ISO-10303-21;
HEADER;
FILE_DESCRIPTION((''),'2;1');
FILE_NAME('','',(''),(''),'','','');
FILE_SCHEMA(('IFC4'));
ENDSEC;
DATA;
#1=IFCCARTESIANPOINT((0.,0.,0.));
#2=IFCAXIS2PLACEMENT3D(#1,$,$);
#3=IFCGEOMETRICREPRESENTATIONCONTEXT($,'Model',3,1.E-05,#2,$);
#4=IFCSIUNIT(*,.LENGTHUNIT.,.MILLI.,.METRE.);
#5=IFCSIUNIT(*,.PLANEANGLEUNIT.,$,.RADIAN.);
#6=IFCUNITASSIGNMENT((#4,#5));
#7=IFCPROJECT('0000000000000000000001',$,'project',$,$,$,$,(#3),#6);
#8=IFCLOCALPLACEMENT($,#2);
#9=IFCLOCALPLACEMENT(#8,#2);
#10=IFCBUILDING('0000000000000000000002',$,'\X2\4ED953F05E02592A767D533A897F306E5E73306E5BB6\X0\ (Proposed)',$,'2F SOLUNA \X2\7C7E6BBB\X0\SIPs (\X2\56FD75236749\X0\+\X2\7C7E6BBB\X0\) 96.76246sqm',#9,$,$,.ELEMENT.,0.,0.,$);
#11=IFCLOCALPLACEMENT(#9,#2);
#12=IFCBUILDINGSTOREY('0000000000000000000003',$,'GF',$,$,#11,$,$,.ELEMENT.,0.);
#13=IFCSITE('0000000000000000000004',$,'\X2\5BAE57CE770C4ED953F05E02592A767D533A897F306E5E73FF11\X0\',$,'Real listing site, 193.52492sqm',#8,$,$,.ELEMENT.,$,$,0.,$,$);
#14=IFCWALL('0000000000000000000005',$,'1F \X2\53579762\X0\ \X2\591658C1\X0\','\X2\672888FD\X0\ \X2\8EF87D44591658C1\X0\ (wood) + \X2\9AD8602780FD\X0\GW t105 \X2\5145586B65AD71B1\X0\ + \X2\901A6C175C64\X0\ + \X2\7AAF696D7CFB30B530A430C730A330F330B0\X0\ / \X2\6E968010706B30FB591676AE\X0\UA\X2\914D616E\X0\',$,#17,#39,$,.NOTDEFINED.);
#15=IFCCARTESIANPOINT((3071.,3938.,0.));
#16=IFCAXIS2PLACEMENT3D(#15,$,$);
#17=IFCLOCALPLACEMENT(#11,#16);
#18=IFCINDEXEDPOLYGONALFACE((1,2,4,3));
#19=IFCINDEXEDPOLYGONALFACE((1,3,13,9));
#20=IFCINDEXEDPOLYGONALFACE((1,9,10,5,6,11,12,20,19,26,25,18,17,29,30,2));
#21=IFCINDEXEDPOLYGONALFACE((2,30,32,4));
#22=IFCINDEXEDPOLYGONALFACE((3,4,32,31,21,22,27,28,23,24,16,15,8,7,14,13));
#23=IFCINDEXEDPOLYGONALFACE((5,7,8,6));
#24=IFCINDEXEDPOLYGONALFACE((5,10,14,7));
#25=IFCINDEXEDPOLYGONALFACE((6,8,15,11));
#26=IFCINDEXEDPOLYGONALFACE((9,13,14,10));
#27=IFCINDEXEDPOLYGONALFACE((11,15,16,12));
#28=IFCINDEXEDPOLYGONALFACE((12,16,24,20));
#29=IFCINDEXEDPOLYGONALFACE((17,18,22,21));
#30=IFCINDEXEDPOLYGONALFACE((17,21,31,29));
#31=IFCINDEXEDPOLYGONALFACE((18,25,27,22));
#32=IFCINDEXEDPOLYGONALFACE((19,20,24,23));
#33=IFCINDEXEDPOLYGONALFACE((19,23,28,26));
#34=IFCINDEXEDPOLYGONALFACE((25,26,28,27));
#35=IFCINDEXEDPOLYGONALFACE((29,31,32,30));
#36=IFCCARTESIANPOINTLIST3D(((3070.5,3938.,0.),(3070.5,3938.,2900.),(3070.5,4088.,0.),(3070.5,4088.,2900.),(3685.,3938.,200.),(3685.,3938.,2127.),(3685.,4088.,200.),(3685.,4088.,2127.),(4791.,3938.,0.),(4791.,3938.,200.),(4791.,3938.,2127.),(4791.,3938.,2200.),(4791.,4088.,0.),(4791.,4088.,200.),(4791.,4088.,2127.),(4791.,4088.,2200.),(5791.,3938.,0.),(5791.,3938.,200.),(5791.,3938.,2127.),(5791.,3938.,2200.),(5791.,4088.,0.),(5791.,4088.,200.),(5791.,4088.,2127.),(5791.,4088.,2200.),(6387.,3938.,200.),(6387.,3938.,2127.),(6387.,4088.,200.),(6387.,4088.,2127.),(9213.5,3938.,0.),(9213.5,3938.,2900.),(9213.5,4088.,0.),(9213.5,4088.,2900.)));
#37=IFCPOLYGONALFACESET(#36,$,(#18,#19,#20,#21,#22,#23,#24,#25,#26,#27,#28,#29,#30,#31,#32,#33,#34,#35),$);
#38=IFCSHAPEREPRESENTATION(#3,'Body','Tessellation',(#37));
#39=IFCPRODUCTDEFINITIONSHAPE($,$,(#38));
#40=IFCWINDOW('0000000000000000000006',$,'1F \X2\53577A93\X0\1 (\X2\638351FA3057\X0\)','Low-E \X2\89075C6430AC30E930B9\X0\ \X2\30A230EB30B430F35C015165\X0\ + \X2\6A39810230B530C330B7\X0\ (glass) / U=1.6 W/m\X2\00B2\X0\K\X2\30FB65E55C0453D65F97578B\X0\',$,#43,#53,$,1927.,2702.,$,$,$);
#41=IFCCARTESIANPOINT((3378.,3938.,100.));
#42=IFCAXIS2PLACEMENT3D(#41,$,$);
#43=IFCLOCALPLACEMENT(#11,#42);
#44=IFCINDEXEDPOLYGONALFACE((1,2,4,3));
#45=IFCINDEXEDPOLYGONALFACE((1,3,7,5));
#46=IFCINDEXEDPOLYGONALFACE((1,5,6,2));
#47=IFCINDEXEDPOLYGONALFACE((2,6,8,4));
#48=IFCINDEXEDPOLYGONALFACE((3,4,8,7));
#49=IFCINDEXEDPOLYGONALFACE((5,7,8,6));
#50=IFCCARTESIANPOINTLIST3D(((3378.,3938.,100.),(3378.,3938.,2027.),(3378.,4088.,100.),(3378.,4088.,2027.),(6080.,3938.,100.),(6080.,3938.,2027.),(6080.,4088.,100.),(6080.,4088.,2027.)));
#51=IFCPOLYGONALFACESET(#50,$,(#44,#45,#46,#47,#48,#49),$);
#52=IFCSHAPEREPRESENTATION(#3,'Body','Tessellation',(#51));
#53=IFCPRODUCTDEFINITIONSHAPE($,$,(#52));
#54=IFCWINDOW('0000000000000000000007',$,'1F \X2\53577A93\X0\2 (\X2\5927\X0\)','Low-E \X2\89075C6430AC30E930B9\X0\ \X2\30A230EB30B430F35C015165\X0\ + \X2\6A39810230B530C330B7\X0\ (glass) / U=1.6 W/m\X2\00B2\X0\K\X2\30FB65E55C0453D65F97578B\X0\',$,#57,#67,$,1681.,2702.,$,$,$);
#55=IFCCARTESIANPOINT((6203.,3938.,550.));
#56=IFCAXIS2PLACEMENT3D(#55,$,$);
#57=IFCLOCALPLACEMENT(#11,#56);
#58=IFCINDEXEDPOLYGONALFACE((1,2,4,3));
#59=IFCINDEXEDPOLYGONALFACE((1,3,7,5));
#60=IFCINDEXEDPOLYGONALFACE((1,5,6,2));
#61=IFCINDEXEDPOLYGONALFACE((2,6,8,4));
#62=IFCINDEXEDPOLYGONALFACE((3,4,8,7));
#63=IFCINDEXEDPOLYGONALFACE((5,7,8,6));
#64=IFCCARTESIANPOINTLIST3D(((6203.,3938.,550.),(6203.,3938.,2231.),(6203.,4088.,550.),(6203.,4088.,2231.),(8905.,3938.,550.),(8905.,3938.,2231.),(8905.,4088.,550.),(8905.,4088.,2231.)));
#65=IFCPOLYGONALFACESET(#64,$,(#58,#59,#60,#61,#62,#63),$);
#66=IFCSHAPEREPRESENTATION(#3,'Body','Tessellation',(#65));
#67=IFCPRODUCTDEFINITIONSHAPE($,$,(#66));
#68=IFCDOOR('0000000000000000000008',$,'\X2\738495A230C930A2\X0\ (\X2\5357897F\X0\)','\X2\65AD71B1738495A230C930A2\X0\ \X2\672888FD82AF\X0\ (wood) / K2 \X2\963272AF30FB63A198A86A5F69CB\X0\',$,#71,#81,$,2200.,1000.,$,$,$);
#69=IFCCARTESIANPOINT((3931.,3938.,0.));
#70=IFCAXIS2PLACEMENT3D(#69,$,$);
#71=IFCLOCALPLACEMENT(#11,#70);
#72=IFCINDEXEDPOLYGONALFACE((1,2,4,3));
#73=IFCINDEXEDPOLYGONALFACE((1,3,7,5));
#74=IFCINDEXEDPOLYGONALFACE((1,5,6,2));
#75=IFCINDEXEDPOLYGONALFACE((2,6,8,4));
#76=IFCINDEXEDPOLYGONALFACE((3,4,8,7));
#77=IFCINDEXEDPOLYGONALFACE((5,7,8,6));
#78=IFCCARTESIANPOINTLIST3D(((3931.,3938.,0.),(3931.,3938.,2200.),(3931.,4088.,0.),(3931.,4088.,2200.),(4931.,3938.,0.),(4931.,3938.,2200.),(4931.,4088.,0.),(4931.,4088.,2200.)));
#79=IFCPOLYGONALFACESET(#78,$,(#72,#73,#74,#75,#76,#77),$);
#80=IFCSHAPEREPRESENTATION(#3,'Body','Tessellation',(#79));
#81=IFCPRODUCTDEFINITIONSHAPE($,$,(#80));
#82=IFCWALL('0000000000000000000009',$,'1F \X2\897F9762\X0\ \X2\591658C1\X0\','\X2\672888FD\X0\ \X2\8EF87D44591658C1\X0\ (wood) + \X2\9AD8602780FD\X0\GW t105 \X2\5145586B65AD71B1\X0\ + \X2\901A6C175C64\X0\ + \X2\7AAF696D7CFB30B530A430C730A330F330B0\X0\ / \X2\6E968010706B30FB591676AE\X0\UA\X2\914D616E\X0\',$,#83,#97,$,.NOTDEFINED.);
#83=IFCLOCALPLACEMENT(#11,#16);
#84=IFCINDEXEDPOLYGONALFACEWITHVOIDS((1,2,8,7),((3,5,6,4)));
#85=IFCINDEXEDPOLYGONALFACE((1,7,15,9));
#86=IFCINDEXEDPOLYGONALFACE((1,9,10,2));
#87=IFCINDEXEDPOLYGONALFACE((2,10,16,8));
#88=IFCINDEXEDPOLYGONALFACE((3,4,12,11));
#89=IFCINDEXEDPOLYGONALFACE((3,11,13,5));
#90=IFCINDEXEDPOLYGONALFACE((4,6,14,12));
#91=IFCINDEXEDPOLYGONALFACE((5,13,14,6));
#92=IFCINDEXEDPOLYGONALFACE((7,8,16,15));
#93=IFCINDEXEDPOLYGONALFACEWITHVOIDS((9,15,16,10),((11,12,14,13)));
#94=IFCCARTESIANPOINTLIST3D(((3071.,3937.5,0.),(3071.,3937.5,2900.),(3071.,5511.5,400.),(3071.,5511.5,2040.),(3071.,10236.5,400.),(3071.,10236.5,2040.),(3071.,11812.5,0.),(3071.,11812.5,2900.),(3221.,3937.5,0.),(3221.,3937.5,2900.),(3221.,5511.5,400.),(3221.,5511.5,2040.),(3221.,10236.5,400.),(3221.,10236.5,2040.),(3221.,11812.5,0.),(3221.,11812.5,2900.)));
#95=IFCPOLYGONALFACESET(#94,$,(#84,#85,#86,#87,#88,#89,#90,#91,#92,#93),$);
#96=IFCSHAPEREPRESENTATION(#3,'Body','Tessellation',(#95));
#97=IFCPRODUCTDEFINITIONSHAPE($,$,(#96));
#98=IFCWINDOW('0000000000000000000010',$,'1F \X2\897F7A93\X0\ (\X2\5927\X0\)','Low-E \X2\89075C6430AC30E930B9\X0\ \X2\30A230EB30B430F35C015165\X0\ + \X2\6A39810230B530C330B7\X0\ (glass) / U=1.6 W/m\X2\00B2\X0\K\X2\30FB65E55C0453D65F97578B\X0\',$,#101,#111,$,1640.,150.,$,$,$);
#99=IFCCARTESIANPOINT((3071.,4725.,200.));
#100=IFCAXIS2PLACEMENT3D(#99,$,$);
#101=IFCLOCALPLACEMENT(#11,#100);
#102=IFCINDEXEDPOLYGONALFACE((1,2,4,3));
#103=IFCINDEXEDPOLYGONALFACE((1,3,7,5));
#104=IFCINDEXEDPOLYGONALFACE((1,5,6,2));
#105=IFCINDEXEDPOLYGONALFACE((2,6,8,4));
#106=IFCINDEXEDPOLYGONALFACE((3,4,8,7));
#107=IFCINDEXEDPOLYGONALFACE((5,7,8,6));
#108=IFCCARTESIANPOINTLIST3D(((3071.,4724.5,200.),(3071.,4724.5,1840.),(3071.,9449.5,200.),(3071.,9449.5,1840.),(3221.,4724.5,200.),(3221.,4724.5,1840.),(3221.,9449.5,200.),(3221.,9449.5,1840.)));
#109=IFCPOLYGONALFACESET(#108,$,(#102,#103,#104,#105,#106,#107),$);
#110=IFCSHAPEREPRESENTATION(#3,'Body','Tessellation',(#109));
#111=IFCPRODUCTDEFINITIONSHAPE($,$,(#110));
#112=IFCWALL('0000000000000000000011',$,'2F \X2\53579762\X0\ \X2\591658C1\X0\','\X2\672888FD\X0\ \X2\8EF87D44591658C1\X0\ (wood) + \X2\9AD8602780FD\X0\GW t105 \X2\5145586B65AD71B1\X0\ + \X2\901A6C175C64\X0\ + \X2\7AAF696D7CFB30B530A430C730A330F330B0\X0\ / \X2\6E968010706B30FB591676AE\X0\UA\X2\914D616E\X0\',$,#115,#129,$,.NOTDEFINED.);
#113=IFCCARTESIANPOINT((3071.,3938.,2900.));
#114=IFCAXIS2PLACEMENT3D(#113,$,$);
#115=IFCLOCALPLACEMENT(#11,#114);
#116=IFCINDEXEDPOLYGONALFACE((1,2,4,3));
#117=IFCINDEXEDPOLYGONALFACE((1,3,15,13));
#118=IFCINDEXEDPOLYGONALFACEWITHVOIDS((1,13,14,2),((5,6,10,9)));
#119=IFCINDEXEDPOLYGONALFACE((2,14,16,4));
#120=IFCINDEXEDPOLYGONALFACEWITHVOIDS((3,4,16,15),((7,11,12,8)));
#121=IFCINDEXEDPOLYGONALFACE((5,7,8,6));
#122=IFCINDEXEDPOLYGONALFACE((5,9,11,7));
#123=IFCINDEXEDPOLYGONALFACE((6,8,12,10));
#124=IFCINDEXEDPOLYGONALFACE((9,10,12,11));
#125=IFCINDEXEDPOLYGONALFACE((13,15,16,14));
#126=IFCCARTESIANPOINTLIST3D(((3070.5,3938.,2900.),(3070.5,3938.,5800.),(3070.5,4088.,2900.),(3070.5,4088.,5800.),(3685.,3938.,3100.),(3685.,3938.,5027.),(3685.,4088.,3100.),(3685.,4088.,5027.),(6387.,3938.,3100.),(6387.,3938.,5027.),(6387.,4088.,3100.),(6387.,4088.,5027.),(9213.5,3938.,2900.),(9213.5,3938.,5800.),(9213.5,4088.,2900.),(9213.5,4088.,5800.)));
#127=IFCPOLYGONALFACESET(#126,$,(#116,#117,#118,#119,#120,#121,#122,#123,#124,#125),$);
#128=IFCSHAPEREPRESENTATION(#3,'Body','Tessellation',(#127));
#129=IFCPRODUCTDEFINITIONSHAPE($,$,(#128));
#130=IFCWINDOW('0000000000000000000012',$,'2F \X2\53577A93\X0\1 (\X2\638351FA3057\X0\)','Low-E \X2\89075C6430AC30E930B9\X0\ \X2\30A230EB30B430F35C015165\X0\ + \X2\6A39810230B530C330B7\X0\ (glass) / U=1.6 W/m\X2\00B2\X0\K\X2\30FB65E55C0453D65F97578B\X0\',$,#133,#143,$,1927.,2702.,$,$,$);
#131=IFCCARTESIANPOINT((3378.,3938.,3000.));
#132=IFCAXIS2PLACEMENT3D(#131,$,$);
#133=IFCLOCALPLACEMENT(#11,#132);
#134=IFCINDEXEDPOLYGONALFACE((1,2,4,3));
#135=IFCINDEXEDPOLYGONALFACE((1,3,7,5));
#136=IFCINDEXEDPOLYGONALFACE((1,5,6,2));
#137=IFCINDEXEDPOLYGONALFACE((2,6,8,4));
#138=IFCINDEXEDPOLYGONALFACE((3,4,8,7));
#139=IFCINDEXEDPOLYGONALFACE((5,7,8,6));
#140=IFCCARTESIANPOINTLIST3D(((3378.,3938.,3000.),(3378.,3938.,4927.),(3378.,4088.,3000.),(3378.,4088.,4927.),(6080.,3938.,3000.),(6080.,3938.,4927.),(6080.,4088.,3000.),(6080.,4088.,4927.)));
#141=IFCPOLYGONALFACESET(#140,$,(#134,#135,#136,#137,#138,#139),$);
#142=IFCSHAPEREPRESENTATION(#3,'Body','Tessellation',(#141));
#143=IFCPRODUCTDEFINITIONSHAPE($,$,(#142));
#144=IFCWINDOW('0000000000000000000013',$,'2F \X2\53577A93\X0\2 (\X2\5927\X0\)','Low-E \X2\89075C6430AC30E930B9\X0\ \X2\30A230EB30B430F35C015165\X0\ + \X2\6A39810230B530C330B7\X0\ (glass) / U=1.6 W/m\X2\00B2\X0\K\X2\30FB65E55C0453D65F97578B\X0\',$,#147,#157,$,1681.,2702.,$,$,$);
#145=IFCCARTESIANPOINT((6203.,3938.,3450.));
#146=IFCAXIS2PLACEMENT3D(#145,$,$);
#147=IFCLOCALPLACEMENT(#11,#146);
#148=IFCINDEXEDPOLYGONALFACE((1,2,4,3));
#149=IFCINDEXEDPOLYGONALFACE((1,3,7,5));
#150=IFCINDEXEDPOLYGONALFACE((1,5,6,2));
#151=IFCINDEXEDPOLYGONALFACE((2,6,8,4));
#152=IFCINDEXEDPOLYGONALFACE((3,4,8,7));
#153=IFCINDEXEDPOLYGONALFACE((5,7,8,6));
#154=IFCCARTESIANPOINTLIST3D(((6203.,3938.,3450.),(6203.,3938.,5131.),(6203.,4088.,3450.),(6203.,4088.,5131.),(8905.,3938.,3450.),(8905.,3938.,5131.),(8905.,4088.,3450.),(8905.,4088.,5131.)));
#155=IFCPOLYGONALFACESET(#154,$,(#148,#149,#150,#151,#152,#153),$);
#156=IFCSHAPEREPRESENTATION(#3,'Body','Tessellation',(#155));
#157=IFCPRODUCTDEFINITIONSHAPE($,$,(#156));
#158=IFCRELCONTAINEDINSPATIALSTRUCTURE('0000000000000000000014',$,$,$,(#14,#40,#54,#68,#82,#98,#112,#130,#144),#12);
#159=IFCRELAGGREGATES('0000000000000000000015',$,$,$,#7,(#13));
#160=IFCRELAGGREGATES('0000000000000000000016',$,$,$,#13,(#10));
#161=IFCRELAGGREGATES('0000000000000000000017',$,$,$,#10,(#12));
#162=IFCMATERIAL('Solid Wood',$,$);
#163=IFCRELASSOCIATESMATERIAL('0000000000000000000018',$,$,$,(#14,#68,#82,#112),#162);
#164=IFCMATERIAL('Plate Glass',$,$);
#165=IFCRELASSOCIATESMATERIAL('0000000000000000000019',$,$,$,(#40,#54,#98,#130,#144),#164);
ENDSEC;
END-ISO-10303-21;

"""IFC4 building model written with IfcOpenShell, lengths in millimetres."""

from ifc_helpers import new_model, si_unit, frame, frame_2d, origin, place, context, project, spatial, rectangle, extrude, material, element, fill, save


model = new_model("IFC4")

# Units and contexts
model_context = context("Model", 3, precision=1e-05, world=origin())
ifc_project = project(units=[si_unit("LENGTHUNIT", "METRE", prefix="MILLI"), si_unit("PLANEANGLEUNIT", "RADIAN")], contexts=[model_context])

# Site, building, storey
site_placement = place(None, origin())
site = spatial("IfcSite", under=ifc_project, at=site_placement, Name="宮城県仙台市太白区西の平１", ObjectType="Real listing site, 193.52492sqm", CompositionType="ELEMENT", RefElevation=0.0)
building_placement = place(site_placement, origin())
building = spatial("IfcBuilding", under=site, at=building_placement, Name="仙台市太白区西の平の家 (Proposed)", ObjectType="2F SOLUNA 籾殻SIPs (国産杉+籾殻) 96.76246sqm", CompositionType="ELEMENT", ElevationOfRefHeight=0.0, ElevationOfTerrain=0.0)
storey_placement = place(building_placement, origin())
storey = spatial("IfcBuildingStorey", under=building, at=storey_placement, Name="GF", CompositionType="ELEMENT", Elevation=0.0)

# Shared definitions
ifc_material_1 = material(Name="Solid Wood")

# Wall, openings, windows, door
wall_1_placement = place(storey_placement, frame((3071.0, 3938.0, 0.0)))
wall_1 = element("IfcWall", 1, at=wall_1_placement, inside=storey, material=ifc_material_1, Name="1F 南面 外壁", Description="木製 軸組外壁 (wood) + 高性能GW t105 充填断熱 + 通気層 + 窯業系サイディング / 準耐火・外皮UA配慮", PredefinedType="NOTDEFINED", context=model_context, shape_type="SweptSolid", body=[
    extrude(rectangle(XDim=6143.0, YDim=150.0, at=frame_2d((3071.0, 75.0))), frame((3071.0, 3938.0, 0.0)), (0.0, 0.0, 1.0), 2900.0),
])
opening_1_placement = place(storey_placement, frame((3378.0, 3938.0, 100.0)))
opening_1 = element("IfcOpeningElement", 2, at=opening_1_placement, cuts=wall_1, PredefinedType="NOTDEFINED", context=model_context, shape_type="SweptSolid", body=[
    extrude(rectangle(XDim=2702.0, YDim=150.0, at=frame_2d((1351.0, 75.0))), frame((3378.0, 3938.0, 100.0)), (0.0, 0.0, 1.0), 1927.0),
])
opening_2_placement = place(storey_placement, frame((6203.0, 3938.0, 550.0)))
opening_2 = element("IfcOpeningElement", 3, at=opening_2_placement, cuts=wall_1, PredefinedType="NOTDEFINED", context=model_context, shape_type="SweptSolid", body=[
    extrude(rectangle(XDim=2702.0, YDim=150.0, at=frame_2d((1351.0, 75.0))), frame((6203.0, 3938.0, 550.0)), (0.0, 0.0, 1.0), 1681.0),
])
opening_3_placement = place(storey_placement, frame((3931.0, 3938.0, 0.0)))
opening_3 = element("IfcOpeningElement", 4, at=opening_3_placement, cuts=wall_1, PredefinedType="NOTDEFINED", context=model_context, shape_type="SweptSolid", body=[
    extrude(rectangle(XDim=1000.0, YDim=150.0, at=frame_2d((500.0, 75.0))), frame((3931.0, 3938.0, 0.0)), (0.0, 0.0, 1.0), 2200.0),
])
ifc_material_2 = material(Name="Plate Glass")
window_1_placement = place(storey_placement, frame((3378.0, 3938.0, 100.0)))
window_1 = element("IfcWindow", 5, at=window_1_placement, inside=storey, material=ifc_material_2, Name="1F 南窓1 (掃出し)", Description="Low-E 複層ガラス アルゴン封入 + 樹脂サッシ (glass) / U=1.6 W/m²K・日射取得型", OverallHeight=1927.0, OverallWidth=2702.0, context=model_context, shape_type="SweptSolid", body=[
    extrude(rectangle(XDim=2702.0, YDim=150.0, at=frame_2d((1351.0, 75.0))), frame((3378.0, 3938.0, 100.0)), (0.0, 0.0, 1.0), 1927.0),
])
fill(opening_1, window_1)
window_2_placement = place(storey_placement, frame((6203.0, 3938.0, 550.0)))
window_2 = element("IfcWindow", 6, at=window_2_placement, inside=storey, material=ifc_material_2, Name="1F 南窓2 (大)", Description="Low-E 複層ガラス アルゴン封入 + 樹脂サッシ (glass) / U=1.6 W/m²K・日射取得型", OverallHeight=1681.0, OverallWidth=2702.0, context=model_context, shape_type="SweptSolid", body=[
    extrude(rectangle(XDim=2702.0, YDim=150.0, at=frame_2d((1351.0, 75.0))), frame((6203.0, 3938.0, 550.0)), (0.0, 0.0, 1.0), 1681.0),
])
fill(opening_2, window_2)
door_placement = place(storey_placement, frame((3931.0, 3938.0, 0.0)))
door = element("IfcDoor", 7, at=door_placement, inside=storey, material=ifc_material_1, Name="玄関ドア (南西)", Description="断熱玄関ドア 木製芯 (wood) / K2 防犯・採風機構", OverallHeight=2200.0, OverallWidth=1000.0, context=model_context, shape_type="SweptSolid", body=[
    extrude(rectangle(XDim=1000.0, YDim=150.0, at=frame_2d((500.0, 75.0))), frame((3931.0, 3938.0, 0.0)), (0.0, 0.0, 1.0), 2200.0),
])
fill(opening_3, door)

# Wall, opening, window
wall_2_placement = place(storey_placement, frame((3071.0, 3938.0, 0.0)))
wall_2 = element("IfcWall", 8, at=wall_2_placement, inside=storey, material=ifc_material_1, Name="1F 西面 外壁", Description="木製 軸組外壁 (wood) + 高性能GW t105 充填断熱 + 通気層 + 窯業系サイディング / 準耐火・外皮UA配慮", PredefinedType="NOTDEFINED", context=model_context, shape_type="SweptSolid", body=[
    extrude(rectangle(XDim=150.0, YDim=7875.0, at=frame_2d((75.0, 3937.0))), frame((3071.0, 3938.0, 0.0)), (0.0, 0.0, 1.0), 2900.0),
])
opening_4_placement = place(storey_placement, frame((3071.0, 4725.0, 200.0)))
opening_4 = element("IfcOpeningElement", 9, at=opening_4_placement, cuts=wall_2, PredefinedType="NOTDEFINED", context=model_context, shape_type="SweptSolid", body=[
    extrude(rectangle(XDim=150.0, YDim=4725.0, at=frame_2d((75.0, 2362.0))), frame((3071.0, 4725.0, 200.0)), (0.0, 0.0, 1.0), 1640.0),
])
window_3_placement = place(storey_placement, frame((3071.0, 4725.0, 200.0)))
window_3 = element("IfcWindow", 10, at=window_3_placement, inside=storey, material=ifc_material_2, Name="1F 西窓 (大)", Description="Low-E 複層ガラス アルゴン封入 + 樹脂サッシ (glass) / U=1.6 W/m²K・日射取得型", OverallHeight=1640.0, OverallWidth=150.0, context=model_context, shape_type="SweptSolid", body=[
    extrude(rectangle(XDim=150.0, YDim=4725.0, at=frame_2d((75.0, 2362.0))), frame((3071.0, 4725.0, 200.0)), (0.0, 0.0, 1.0), 1640.0),
])
fill(opening_4, window_3)

# Wall, openings, windows
wall_3_placement = place(storey_placement, frame((3071.0, 3938.0, 2900.0)))
wall_3 = element("IfcWall", 11, at=wall_3_placement, inside=storey, material=ifc_material_1, Name="2F 南面 外壁", Description="木製 軸組外壁 (wood) + 高性能GW t105 充填断熱 + 通気層 + 窯業系サイディング / 準耐火・外皮UA配慮", PredefinedType="NOTDEFINED", context=model_context, shape_type="SweptSolid", body=[
    extrude(rectangle(XDim=6143.0, YDim=150.0, at=frame_2d((3071.0, 75.0))), frame((3071.0, 3938.0, 2900.0)), (0.0, 0.0, 1.0), 2900.0),
])
opening_5_placement = place(storey_placement, frame((3378.0, 3938.0, 3000.0)))
opening_5 = element("IfcOpeningElement", 12, at=opening_5_placement, cuts=wall_3, PredefinedType="NOTDEFINED", context=model_context, shape_type="SweptSolid", body=[
    extrude(rectangle(XDim=2702.0, YDim=150.0, at=frame_2d((1351.0, 75.0))), frame((3378.0, 3938.0, 3000.0)), (0.0, 0.0, 1.0), 1927.0),
])
opening_6_placement = place(storey_placement, frame((6203.0, 3938.0, 3450.0)))
opening_6 = element("IfcOpeningElement", 13, at=opening_6_placement, cuts=wall_3, PredefinedType="NOTDEFINED", context=model_context, shape_type="SweptSolid", body=[
    extrude(rectangle(XDim=2702.0, YDim=150.0, at=frame_2d((1351.0, 75.0))), frame((6203.0, 3938.0, 3450.0)), (0.0, 0.0, 1.0), 1681.0),
])
window_4_placement = place(storey_placement, frame((3378.0, 3938.0, 3000.0)))
window_4 = element("IfcWindow", 14, at=window_4_placement, inside=storey, material=ifc_material_2, Name="2F 南窓1 (掃出し)", Description="Low-E 複層ガラス アルゴン封入 + 樹脂サッシ (glass) / U=1.6 W/m²K・日射取得型", OverallHeight=1927.0, OverallWidth=2702.0, context=model_context, shape_type="SweptSolid", body=[
    extrude(rectangle(XDim=2702.0, YDim=150.0, at=frame_2d((1351.0, 75.0))), frame((3378.0, 3938.0, 3000.0)), (0.0, 0.0, 1.0), 1927.0),
])
fill(opening_5, window_4)
window_5_placement = place(storey_placement, frame((6203.0, 3938.0, 3450.0)))
window_5 = element("IfcWindow", 15, at=window_5_placement, inside=storey, material=ifc_material_2, Name="2F 南窓2 (大)", Description="Low-E 複層ガラス アルゴン封入 + 樹脂サッシ (glass) / U=1.6 W/m²K・日射取得型", OverallHeight=1681.0, OverallWidth=2702.0, context=model_context, shape_type="SweptSolid", body=[
    extrude(rectangle(XDim=2702.0, YDim=150.0, at=frame_2d((1351.0, 75.0))), frame((6203.0, 3938.0, 3450.0)), (0.0, 0.0, 1.0), 1681.0),
])
fill(opening_6, window_5)

save(model, "model.ifc")
